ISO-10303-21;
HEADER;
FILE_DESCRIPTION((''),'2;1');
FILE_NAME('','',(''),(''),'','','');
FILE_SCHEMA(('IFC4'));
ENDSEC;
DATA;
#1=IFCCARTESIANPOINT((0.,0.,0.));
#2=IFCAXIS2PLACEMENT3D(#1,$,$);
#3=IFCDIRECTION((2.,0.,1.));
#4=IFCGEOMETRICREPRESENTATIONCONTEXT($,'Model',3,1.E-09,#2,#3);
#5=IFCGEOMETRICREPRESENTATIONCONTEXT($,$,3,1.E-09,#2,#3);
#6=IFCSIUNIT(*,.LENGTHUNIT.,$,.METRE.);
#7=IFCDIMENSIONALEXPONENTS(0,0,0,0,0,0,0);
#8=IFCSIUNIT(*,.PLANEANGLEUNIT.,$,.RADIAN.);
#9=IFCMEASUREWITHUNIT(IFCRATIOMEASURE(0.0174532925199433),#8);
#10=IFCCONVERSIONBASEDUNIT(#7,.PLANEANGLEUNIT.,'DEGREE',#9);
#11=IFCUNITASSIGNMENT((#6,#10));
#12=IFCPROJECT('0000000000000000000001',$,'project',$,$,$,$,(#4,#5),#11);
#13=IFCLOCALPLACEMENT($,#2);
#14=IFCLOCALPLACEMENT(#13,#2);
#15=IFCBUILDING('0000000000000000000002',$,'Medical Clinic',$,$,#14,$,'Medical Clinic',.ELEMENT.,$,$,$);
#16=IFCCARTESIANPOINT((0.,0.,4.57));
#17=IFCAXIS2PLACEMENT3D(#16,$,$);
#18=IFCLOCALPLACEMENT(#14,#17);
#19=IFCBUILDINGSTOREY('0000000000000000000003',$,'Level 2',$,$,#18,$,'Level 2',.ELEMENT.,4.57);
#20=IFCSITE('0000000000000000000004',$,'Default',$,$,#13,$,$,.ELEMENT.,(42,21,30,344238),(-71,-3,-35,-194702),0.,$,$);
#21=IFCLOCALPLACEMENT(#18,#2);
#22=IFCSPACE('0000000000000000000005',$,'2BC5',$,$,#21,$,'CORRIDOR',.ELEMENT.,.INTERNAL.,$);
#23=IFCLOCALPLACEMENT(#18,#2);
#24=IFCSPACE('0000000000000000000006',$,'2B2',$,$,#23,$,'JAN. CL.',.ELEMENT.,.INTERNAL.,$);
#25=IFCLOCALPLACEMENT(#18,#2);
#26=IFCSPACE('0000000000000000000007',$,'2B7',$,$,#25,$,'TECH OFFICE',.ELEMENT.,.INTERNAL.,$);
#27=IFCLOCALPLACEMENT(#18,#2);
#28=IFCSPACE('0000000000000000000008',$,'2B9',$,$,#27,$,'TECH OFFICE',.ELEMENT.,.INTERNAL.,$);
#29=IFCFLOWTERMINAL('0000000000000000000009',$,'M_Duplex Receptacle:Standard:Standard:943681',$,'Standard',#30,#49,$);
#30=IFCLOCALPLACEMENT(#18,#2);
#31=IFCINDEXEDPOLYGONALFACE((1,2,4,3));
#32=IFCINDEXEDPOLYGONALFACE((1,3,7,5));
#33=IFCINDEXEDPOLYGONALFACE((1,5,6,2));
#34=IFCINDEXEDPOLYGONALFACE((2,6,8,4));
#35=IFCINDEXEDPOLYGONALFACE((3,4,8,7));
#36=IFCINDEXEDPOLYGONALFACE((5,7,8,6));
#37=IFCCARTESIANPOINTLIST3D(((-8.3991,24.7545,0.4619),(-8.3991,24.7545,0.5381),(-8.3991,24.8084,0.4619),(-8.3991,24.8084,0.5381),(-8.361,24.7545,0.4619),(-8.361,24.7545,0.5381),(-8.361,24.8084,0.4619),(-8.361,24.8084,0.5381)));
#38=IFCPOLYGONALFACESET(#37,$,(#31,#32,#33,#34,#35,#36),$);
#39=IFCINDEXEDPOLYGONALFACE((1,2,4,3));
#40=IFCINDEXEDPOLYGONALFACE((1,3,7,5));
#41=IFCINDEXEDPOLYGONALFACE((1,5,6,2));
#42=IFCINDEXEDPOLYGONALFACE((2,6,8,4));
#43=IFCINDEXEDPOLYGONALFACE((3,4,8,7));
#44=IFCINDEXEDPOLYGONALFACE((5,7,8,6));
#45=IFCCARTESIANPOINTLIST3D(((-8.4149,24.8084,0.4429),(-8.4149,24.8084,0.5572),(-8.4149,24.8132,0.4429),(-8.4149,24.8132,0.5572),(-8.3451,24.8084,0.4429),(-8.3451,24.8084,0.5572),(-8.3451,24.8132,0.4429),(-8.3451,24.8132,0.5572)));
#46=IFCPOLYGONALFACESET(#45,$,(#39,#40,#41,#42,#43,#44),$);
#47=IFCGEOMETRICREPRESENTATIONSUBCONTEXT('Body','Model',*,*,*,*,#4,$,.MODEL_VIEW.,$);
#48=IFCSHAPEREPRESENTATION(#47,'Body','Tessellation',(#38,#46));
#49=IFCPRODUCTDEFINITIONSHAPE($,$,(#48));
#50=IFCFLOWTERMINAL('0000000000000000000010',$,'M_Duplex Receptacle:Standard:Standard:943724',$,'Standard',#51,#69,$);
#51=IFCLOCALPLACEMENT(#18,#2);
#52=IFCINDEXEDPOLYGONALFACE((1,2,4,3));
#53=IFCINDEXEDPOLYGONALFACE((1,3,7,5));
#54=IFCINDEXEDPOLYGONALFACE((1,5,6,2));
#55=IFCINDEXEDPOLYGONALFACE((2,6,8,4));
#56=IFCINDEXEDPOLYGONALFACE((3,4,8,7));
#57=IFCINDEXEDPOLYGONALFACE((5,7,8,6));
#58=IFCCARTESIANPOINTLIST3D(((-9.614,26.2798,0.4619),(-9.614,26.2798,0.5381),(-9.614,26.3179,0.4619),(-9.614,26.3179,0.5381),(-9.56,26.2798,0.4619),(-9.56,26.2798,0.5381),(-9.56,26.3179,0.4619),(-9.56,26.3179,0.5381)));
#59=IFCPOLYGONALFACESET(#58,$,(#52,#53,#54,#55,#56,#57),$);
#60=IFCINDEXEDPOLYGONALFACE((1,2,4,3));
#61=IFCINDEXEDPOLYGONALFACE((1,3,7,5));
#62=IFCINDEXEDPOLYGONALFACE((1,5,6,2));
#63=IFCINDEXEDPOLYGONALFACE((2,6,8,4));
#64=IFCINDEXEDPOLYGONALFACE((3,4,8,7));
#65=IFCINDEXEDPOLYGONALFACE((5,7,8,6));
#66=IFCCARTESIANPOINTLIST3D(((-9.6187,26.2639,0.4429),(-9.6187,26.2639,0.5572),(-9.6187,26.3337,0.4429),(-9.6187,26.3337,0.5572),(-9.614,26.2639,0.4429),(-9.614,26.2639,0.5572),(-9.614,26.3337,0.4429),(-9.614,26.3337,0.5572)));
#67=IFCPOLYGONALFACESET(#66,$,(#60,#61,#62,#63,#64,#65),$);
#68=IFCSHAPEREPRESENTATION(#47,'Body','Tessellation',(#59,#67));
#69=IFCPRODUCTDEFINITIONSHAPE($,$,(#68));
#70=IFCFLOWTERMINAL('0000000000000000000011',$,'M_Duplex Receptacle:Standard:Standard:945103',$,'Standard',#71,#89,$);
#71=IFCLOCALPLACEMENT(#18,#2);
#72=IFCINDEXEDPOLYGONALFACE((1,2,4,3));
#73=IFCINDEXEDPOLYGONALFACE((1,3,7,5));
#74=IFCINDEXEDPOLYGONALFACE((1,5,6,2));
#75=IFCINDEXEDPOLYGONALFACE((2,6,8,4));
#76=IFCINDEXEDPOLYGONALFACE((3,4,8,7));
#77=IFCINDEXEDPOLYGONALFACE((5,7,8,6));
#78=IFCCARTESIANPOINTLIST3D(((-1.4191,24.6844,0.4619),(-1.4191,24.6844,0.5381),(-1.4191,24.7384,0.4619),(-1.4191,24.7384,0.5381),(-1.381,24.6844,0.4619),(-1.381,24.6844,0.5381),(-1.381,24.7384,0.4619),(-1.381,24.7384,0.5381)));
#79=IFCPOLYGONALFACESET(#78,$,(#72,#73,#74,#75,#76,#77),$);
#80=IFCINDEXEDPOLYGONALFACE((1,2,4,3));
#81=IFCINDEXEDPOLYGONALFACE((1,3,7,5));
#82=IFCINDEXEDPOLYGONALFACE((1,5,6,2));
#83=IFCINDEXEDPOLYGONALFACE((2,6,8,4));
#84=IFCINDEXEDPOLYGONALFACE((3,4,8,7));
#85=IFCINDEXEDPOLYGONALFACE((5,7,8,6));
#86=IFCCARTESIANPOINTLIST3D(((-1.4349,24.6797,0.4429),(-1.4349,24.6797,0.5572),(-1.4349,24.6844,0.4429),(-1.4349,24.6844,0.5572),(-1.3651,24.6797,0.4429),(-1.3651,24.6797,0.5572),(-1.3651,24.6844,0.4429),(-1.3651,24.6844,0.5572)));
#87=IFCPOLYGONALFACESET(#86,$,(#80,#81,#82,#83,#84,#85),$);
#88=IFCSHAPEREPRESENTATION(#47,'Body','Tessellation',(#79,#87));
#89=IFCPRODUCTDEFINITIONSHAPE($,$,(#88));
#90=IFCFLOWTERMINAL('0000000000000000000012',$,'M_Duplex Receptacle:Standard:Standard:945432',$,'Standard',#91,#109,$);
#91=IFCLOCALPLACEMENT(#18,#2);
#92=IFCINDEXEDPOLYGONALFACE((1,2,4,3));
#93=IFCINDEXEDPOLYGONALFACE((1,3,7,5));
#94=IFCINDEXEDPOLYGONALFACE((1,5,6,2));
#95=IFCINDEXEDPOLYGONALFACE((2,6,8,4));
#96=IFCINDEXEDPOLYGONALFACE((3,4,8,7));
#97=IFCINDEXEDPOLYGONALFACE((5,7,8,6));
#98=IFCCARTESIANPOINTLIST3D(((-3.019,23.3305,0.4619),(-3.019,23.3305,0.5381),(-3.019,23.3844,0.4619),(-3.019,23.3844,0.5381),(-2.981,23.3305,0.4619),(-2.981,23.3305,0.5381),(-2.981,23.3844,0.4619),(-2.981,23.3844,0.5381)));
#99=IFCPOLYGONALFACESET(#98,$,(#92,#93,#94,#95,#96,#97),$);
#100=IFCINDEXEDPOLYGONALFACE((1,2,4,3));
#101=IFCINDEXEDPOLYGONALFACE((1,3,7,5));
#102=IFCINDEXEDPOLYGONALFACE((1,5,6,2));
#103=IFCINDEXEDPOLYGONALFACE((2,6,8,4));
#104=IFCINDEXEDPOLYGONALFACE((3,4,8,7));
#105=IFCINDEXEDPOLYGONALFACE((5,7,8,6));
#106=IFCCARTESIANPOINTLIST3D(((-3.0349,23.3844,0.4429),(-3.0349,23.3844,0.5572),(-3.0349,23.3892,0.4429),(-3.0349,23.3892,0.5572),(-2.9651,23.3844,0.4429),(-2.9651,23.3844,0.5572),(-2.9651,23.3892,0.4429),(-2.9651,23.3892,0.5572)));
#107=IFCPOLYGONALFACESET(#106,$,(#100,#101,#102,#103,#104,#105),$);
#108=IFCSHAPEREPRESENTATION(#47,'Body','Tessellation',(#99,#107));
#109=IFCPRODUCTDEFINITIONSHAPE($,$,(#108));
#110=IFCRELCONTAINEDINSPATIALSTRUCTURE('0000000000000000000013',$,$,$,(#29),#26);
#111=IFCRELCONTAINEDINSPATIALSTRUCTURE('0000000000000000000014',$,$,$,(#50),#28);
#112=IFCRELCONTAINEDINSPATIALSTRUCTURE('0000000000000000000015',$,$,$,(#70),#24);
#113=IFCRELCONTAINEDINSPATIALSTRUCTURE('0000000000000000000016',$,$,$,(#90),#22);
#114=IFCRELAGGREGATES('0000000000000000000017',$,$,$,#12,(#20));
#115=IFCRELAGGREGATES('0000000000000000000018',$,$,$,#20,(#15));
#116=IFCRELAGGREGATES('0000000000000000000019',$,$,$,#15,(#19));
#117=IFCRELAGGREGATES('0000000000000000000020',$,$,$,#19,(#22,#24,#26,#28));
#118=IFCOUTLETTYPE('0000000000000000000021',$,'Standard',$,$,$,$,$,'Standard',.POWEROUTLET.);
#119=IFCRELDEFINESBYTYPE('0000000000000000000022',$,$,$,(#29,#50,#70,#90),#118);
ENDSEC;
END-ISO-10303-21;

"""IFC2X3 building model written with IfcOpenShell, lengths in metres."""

from ifc_helpers import new_model, entity, si_unit, converted_unit, direction, frame, frame_2d, origin, origin_2d_with_axis, place, context, subcontext, project, spatial, rectangle, extrude, source, transform, mapped, type_object, type_shapes, element, save


model = new_model("IFC2X3")

# Units and contexts
model_context = context("Model", 3, precision=1e-09, world=origin(), true_north=direction((2.0, 0.0, 1.0)))
context_of_model = context(None, 3, precision=1e-09, world=origin(), true_north=direction((2.0, 0.0, 1.0)))
body_context = subcontext(model_context, "Body", "Model", "MODEL_VIEW")
ifc_project = project(units=[si_unit("LENGTHUNIT", "METRE"), converted_unit("PLANEANGLEUNIT", "DEGREE", entity("IfcRatioMeasure", 0.0174532925199433), si_unit("PLANEANGLEUNIT", "RADIAN"), dimensions=[0, 0, 0, 0, 0, 0, 0])], contexts=[model_context, context_of_model])

# Site, building, storey, space
site_placement = place(None, origin())
site = spatial("IfcSite", under=ifc_project, at=site_placement, Name="Default", CompositionType="ELEMENT", RefLatitude=(42, 21, 30, 344238), RefLongitude=(-71, -3, -35, -194702), RefElevation=0.0)
building_placement = place(site_placement, origin())
building = spatial("IfcBuilding", under=site, at=building_placement, Name="Medical Clinic", LongName="Medical Clinic", CompositionType="ELEMENT")
storey_placement = place(building_placement, frame((0.0, 0.0, 4.57)))
storey = spatial("IfcBuildingStorey", under=building, at=storey_placement, Name="Level 2", LongName="Level 2", CompositionType="ELEMENT", Elevation=4.57)
space_1_placement = place(storey_placement, origin())
space_1 = spatial("IfcSpace", under=storey, at=space_1_placement, Name="2BC5", LongName="CORRIDOR", CompositionType="ELEMENT", InteriorOrExteriorSpace="INTERNAL")

# Shared definitions
space_2_placement = place(storey_placement, origin())
space_2 = spatial("IfcSpace", under=storey, at=space_2_placement, Name="2B2", LongName="JAN. CL.", CompositionType="ELEMENT", InteriorOrExteriorSpace="INTERNAL")

# Shared definitions
space_3_placement = place(storey_placement, origin())
space_3 = spatial("IfcSpace", under=storey, at=space_3_placement, Name="2B7", LongName="TECH OFFICE", CompositionType="ELEMENT", InteriorOrExteriorSpace="INTERNAL")

# Flow terminal
outlet_type = type_object("IfcOutletType", Name="Standard", ElementType="Standard", PredefinedType="POWEROUTLET")
shared_shape_1 = source(origin(), body_context, "Body", "SweptSolid", [
    extrude(rectangle(XDim=0.0381, YDim=0.0762, at=origin_2d_with_axis()), frame((0.0, 0.0, -0.054), z_axis=(0.0, 0.0, 1.0), x_axis=(-1.0, 0.0, 0.0)), (0.0, 0.0, 1.0), 0.054),
    extrude(rectangle(XDim=0.0698, YDim=0.1143, at=frame_2d((0.0, 0.0), x_axis=(1.0, 0.0))), frame((0.0, 0.0, 0.0), z_axis=(0.0, 0.0, 1.0), x_axis=(-1.0, 0.0, 0.0)), (0.0, 0.0, 1.0), 0.0048),
])
type_shapes(outlet_type, [shared_shape_1])
for number, where, z_axis, x_axis, name in (
    (1, (-8.38, 24.8084, 0.5), (0.0, 1.0, 0.0), (-1.0, 0.0, 0.0), "M_Duplex Receptacle:Standard:Standard:943681"),
):
    element("IfcFlowTerminal", number, at=place(space_3_placement, frame(where, z_axis=z_axis, x_axis=x_axis)), inside=space_3, type_object=outlet_type, Name=name, ObjectType="Standard", context=body_context, shape_type="MappedRepresentation", body=[
        mapped(shared_shape_1, transform((0.0, 0.0, 0.0), scale=1.0)),
    ])

# Shared definitions
space_4_placement = place(storey_placement, origin())
space_4 = spatial("IfcSpace", under=storey, at=space_4_placement, Name="2B9", LongName="TECH OFFICE", CompositionType="ELEMENT", InteriorOrExteriorSpace="INTERNAL")

# Flow terminals
flow_terminal_1_placement = place(space_4_placement, frame((-9.614, 26.2988, 0.5), z_axis=(-1.0, 0.0, 0.0), x_axis=(0.0, -1.0, 0.0)))
element("IfcFlowTerminal", 2, at=flow_terminal_1_placement, inside=space_4, type_object=outlet_type, Name="M_Duplex Receptacle:Standard:Standard:943724", ObjectType="Standard", context=body_context, shape_type="MappedRepresentation", body=[
    mapped(shared_shape_1, transform((0.0, 0.0, 0.0), scale=1.0)),
])
flow_terminal_2_placement = place(space_2_placement, frame((-1.4, 24.6844, 0.5), z_axis=(0.0, -1.0, 0.0), x_axis=(1.0, 0.0, 0.0)))
element("IfcFlowTerminal", 3, at=flow_terminal_2_placement, inside=space_2, type_object=outlet_type, Name="M_Duplex Receptacle:Standard:Standard:945103", ObjectType="Standard", context=body_context, shape_type="MappedRepresentation", body=[
    mapped(shared_shape_1, transform((0.0, 0.0, 0.0), scale=1.0)),
])
flow_terminal_3_placement = place(space_1_placement, frame((-3.0, 23.3844, 0.5), z_axis=(0.0, 1.0, 0.0), x_axis=(-1.0, 0.0, 0.0)))
element("IfcFlowTerminal", 4, at=flow_terminal_3_placement, inside=space_1, type_object=outlet_type, Name="M_Duplex Receptacle:Standard:Standard:945432", ObjectType="Standard", context=body_context, shape_type="MappedRepresentation", body=[
    mapped(shared_shape_1, transform((0.0, 0.0, 0.0), scale=1.0)),
])

save(model, "model.ifc")
